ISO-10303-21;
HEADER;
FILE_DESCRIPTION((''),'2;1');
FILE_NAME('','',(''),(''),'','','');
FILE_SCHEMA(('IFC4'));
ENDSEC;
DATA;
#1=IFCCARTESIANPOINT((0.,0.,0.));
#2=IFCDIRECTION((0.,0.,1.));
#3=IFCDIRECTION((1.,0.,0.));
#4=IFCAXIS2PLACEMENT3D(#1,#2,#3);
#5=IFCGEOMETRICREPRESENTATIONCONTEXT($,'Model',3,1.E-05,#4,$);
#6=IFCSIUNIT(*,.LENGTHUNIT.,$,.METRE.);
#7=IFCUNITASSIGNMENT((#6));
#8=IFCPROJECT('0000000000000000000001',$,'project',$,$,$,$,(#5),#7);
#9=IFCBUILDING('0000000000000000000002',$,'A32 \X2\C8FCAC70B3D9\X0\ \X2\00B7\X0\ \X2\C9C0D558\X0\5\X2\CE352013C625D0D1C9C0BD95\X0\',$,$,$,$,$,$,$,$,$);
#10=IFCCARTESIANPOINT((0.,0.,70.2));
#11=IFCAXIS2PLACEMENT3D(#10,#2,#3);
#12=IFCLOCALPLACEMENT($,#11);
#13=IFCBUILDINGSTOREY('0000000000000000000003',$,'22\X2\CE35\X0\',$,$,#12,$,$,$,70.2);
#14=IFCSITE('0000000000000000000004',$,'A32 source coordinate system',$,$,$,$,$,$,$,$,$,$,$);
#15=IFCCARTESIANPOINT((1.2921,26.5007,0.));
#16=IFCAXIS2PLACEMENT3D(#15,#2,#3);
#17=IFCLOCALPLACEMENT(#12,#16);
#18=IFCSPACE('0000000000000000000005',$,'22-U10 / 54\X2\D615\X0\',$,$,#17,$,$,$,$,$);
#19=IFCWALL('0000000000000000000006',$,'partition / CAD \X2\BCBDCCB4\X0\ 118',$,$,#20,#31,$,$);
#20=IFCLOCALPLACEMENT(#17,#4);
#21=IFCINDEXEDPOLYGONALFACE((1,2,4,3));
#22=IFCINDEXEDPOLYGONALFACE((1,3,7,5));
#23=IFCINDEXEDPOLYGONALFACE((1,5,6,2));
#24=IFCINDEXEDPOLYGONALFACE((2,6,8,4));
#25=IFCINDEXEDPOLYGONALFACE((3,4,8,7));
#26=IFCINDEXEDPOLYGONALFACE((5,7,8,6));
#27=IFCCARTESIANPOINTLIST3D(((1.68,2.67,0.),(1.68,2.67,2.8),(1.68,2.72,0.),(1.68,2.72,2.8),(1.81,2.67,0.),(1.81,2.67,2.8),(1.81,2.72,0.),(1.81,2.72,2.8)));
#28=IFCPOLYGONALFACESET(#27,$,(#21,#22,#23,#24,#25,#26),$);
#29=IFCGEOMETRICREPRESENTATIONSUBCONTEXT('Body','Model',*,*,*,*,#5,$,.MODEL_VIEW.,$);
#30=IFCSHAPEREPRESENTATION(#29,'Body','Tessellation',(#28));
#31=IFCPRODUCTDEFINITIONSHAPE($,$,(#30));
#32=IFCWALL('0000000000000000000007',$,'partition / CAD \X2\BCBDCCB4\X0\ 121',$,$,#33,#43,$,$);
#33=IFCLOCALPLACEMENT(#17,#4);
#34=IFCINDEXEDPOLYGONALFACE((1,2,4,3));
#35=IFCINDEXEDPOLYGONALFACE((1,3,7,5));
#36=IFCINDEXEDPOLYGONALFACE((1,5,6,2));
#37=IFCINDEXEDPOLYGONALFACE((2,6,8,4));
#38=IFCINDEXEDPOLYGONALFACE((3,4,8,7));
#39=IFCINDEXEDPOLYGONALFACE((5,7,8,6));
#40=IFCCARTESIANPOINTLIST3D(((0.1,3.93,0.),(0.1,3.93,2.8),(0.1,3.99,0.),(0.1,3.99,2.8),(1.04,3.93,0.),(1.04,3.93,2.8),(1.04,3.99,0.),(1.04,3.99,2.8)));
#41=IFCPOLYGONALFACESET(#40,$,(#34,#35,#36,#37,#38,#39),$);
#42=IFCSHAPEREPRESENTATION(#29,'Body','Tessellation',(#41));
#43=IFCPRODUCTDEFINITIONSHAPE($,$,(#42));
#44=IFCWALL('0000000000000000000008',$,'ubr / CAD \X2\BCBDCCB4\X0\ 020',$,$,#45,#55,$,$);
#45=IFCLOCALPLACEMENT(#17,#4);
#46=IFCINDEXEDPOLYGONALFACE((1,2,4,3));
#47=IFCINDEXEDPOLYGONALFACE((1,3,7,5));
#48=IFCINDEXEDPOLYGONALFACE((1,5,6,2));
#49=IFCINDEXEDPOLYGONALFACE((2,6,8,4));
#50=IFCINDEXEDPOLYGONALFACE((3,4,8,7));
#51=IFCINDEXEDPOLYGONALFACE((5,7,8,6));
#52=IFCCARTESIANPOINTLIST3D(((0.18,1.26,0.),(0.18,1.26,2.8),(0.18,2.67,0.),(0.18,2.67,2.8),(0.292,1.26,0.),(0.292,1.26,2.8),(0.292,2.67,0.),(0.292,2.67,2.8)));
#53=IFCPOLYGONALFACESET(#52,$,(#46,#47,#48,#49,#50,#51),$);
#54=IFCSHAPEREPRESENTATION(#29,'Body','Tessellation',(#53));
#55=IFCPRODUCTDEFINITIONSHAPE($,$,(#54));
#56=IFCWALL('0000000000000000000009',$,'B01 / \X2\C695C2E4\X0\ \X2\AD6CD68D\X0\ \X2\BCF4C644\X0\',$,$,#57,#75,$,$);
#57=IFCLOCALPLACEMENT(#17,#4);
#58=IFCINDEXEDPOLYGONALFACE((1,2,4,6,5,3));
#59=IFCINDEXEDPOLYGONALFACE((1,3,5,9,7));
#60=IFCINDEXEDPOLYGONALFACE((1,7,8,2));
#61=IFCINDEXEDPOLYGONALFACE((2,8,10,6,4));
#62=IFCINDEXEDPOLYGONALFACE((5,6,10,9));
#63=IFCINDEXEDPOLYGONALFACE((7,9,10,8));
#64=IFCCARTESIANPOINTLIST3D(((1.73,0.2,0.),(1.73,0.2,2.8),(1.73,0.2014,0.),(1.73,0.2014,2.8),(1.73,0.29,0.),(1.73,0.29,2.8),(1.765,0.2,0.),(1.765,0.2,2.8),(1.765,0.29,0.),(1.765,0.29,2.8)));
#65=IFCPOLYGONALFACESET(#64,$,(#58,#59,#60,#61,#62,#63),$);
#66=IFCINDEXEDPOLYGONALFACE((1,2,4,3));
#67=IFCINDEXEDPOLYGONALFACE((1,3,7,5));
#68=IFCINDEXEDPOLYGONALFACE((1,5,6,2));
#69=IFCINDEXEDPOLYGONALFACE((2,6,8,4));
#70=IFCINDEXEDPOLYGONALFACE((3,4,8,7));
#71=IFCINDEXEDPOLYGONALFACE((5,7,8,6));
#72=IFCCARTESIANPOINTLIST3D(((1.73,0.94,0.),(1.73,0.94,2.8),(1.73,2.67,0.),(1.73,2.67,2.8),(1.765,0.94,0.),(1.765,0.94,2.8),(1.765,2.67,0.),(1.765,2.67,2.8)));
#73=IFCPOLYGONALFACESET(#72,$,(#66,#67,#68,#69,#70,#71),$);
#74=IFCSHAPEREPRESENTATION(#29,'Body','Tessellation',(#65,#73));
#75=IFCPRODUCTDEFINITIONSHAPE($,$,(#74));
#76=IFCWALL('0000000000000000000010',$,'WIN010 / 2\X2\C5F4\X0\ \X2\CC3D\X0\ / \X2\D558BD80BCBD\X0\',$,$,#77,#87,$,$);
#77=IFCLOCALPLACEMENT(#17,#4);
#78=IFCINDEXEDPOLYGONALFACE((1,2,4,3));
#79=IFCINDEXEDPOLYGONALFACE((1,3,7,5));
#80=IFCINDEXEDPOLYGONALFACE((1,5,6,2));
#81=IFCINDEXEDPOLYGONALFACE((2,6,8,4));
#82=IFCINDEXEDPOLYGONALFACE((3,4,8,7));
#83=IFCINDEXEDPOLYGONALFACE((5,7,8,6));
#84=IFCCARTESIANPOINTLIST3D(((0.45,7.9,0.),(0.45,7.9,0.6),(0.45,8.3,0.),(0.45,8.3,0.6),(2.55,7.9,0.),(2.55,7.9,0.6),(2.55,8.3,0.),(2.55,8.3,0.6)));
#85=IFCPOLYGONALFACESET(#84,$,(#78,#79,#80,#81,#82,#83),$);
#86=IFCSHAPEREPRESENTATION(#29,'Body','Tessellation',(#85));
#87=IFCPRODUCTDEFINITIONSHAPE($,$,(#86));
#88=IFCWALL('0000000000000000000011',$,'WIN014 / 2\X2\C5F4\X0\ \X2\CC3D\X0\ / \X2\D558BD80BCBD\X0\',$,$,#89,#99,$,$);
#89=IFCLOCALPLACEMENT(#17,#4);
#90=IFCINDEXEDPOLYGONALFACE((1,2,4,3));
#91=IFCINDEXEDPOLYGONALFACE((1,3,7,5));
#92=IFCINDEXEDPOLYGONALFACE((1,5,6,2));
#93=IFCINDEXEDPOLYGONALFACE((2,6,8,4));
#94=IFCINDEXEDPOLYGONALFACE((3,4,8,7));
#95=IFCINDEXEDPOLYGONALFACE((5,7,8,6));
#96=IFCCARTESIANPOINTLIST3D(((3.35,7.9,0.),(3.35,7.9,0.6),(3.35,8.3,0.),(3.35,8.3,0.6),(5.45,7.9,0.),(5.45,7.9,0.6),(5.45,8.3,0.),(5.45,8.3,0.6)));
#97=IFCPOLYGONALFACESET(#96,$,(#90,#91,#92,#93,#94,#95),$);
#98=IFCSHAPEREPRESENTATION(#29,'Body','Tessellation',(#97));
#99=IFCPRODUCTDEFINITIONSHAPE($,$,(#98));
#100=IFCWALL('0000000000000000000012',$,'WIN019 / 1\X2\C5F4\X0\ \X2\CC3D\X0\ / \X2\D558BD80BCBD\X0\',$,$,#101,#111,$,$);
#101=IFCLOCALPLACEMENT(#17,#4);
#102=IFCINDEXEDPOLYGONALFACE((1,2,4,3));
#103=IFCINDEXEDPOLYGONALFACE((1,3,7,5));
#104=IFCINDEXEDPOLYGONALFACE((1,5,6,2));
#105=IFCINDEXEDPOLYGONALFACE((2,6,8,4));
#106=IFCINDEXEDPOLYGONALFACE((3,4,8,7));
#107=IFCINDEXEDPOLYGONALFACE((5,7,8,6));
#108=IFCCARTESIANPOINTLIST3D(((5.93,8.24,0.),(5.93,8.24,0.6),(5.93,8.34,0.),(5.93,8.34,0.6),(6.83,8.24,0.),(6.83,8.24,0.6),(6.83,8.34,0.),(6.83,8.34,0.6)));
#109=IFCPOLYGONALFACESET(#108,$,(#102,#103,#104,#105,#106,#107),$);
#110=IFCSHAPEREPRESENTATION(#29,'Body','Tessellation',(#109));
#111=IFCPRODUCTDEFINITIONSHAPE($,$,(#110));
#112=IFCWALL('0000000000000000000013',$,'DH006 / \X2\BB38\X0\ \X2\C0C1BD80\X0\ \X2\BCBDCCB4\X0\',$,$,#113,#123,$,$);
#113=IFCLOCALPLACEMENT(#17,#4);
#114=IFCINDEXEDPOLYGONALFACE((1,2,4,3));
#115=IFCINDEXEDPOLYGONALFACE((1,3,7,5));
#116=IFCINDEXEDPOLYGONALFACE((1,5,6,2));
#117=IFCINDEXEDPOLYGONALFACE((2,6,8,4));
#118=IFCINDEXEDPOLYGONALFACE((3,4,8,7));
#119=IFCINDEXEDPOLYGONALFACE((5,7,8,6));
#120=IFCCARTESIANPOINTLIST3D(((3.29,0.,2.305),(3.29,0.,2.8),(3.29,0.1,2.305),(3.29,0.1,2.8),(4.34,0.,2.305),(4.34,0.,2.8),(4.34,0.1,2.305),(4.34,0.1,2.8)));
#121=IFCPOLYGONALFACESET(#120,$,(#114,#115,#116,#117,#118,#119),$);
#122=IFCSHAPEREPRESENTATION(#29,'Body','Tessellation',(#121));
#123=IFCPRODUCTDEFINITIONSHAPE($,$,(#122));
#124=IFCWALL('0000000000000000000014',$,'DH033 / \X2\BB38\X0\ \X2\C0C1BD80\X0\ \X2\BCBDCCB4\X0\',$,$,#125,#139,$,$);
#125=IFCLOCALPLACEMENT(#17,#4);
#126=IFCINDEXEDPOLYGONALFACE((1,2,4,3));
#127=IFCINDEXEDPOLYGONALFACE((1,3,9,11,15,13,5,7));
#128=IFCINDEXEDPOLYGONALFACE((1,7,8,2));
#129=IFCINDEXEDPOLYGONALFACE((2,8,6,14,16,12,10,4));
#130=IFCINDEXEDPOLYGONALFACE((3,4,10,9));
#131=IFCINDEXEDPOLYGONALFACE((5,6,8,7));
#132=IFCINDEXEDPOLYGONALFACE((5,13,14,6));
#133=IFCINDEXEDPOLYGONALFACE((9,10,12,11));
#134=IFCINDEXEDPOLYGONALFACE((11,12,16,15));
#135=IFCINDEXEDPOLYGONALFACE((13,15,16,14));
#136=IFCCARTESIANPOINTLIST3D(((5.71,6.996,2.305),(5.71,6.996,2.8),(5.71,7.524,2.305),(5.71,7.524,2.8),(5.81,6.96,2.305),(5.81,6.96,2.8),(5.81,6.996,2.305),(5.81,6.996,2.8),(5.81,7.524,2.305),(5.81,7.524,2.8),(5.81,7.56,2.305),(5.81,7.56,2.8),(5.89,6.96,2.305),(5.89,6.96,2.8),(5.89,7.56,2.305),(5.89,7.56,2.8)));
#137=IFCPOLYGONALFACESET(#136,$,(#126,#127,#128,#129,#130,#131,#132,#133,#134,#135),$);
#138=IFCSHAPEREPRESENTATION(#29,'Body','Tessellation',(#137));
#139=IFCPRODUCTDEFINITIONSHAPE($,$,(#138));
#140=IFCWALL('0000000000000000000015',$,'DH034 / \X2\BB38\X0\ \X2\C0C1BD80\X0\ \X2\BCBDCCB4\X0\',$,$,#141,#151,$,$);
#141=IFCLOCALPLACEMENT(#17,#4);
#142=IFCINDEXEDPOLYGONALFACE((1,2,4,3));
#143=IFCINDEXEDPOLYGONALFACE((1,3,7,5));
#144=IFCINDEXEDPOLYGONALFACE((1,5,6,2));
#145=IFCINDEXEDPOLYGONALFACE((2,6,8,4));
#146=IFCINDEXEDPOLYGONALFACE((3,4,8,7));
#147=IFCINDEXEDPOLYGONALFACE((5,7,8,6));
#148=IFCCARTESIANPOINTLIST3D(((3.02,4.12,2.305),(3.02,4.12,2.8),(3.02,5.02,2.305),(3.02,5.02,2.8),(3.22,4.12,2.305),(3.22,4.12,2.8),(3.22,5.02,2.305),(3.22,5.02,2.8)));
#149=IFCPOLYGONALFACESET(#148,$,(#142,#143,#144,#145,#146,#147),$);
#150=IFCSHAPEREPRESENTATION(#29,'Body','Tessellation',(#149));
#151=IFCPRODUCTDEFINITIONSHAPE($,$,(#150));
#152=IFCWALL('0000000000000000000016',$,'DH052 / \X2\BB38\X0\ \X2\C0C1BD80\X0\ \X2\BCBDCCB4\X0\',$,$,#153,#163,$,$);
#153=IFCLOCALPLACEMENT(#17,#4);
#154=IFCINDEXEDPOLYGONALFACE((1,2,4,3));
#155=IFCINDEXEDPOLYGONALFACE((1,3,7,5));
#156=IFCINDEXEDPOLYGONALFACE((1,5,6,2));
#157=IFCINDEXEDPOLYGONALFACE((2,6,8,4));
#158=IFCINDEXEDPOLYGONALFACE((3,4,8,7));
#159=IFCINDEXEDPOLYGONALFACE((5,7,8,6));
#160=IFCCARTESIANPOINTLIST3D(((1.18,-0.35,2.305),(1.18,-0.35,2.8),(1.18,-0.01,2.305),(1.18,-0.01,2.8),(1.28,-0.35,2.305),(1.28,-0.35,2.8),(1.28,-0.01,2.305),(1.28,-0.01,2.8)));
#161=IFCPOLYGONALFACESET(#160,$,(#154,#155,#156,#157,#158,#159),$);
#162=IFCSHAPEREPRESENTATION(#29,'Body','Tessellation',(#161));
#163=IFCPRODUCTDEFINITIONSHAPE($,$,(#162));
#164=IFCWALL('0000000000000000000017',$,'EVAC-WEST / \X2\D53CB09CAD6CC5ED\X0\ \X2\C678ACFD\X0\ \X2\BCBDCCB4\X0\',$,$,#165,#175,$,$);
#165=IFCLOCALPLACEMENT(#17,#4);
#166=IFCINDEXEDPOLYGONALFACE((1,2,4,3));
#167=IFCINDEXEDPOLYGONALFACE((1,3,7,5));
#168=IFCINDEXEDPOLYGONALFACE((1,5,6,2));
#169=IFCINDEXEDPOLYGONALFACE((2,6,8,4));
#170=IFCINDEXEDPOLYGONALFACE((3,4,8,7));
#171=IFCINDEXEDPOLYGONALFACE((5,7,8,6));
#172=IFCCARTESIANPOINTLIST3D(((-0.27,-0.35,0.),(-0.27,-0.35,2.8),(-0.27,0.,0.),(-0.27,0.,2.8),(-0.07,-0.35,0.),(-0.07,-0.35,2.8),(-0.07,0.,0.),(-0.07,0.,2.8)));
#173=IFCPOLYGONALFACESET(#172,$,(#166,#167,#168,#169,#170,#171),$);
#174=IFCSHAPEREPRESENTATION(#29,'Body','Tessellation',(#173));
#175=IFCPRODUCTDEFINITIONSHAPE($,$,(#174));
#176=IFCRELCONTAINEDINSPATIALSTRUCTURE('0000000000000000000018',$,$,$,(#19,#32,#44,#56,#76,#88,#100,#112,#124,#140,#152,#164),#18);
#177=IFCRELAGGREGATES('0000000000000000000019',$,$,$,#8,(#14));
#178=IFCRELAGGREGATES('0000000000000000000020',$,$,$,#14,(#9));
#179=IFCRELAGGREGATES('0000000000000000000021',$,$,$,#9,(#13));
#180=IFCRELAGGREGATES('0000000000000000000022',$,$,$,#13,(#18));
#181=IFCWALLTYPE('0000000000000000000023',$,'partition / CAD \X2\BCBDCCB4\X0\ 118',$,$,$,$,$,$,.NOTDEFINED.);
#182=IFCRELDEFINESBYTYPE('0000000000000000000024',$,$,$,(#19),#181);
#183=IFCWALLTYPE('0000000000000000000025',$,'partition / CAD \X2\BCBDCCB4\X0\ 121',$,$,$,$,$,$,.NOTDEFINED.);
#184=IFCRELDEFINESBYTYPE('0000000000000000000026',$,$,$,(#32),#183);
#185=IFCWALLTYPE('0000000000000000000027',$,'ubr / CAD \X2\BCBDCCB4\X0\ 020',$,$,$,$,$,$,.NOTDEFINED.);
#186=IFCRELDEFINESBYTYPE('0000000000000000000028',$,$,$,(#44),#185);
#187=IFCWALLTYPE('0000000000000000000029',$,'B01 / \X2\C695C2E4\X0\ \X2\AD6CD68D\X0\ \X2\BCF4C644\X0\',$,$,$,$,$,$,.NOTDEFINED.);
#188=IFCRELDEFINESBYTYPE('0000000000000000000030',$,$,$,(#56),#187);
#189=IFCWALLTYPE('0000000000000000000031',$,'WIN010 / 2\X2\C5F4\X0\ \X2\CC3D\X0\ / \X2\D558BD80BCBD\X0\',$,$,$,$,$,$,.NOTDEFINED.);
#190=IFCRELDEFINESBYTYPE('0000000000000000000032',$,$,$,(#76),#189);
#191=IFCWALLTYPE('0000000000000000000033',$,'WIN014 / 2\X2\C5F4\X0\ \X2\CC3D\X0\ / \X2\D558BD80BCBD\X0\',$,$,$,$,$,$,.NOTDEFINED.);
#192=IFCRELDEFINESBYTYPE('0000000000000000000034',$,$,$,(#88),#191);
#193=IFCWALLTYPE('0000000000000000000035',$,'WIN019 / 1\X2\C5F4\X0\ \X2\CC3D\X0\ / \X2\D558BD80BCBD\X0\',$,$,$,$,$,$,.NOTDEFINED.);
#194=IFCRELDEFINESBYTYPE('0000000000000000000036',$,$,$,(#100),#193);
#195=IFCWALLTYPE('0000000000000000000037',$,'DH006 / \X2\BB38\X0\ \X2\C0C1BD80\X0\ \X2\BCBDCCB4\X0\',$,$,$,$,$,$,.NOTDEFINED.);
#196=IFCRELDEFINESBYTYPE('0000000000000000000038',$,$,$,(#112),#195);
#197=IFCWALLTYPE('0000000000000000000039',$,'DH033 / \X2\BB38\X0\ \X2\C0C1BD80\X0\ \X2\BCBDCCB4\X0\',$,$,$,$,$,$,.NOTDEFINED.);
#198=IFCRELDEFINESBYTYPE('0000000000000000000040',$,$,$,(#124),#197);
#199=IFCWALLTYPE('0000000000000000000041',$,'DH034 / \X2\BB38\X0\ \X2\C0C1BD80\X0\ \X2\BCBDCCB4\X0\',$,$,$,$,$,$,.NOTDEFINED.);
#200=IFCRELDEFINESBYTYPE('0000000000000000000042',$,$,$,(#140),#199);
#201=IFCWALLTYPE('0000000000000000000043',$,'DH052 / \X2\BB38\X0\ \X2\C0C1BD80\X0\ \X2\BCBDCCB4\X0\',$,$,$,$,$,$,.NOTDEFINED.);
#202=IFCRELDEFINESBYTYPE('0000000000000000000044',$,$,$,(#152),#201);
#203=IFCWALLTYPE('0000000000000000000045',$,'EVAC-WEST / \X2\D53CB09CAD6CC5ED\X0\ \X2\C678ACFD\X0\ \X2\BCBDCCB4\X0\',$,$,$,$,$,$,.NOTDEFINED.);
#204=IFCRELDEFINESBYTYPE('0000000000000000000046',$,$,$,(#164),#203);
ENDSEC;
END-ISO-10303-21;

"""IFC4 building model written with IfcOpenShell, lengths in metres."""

from ifc_helpers import new_model, si_unit, frame, origin, origin_with_axes, place, context, subcontext, project, spatial, polyline, outline, extrude, source, transform, mapped, type_object, type_shapes, element, save


model = new_model("IFC4")

# Units and contexts
model_context = context("Model", 3, precision=1e-05, world=origin_with_axes())
body_context = subcontext(model_context, "Body", "Model", "MODEL_VIEW")
ifc_project = project(units=[si_unit("LENGTHUNIT", "METRE")], contexts=[model_context])

# Site, building, storey, space
site = spatial("IfcSite", under=ifc_project, Name="A32 source coordinate system")
building = spatial("IfcBuilding", under=site, Name="A32 주거동 · 지하5층–옥탑지붕")
storey_placement = place(None, frame((0.0, 0.0, 70.2), z_axis=(0.0, 0.0, 1.0), x_axis=(1.0, 0.0, 0.0)))
storey = spatial("IfcBuildingStorey", under=building, at=storey_placement, Name="22층", Elevation=70.2)
space_placement = place(storey_placement, frame((1.2921, 26.5007, 0.0), z_axis=(0.0, 0.0, 1.0), x_axis=(1.0, 0.0, 0.0)))
space = spatial("IfcSpace", under=storey, at=space_placement, Name="22-U10 / 54형")

# Walls
wall_type_1 = type_object("IfcWallType", Name="partition / CAD 벽체 118", PredefinedType="NOTDEFINED")
shared_shape_1 = source(origin(), body_context, "Body", "SweptSolid", [
    extrude(outline(polyline([(1.81, 2.67), (1.68, 2.67), (1.68, 2.72), (1.81, 2.72), (1.81, 2.67)])), origin(), (0.0, 0.0, 1.0), 2.8),
])
type_shapes(wall_type_1, [shared_shape_1])
wall_1_placement = place(space_placement, origin_with_axes())
element("IfcWall", 1, at=wall_1_placement, inside=space, type_object=wall_type_1, Name="partition / CAD 벽체 118", context=body_context, shape_type="MappedRepresentation", body=[
    mapped(shared_shape_1, transform((0.0, 0.0, 0.0), scale=1.0)),
])
wall_type_2 = type_object("IfcWallType", Name="partition / CAD 벽체 121", PredefinedType="NOTDEFINED")
shared_shape_2 = source(origin(), body_context, "Body", "SweptSolid", [
    extrude(outline(polyline([(0.1, 3.99), (1.04, 3.99), (1.04, 3.93), (0.1, 3.93), (0.1, 3.99)])), origin(), (0.0, 0.0, 1.0), 2.8),
])
type_shapes(wall_type_2, [shared_shape_2])
wall_2_placement = place(space_placement, origin_with_axes())
element("IfcWall", 2, at=wall_2_placement, inside=space, type_object=wall_type_2, Name="partition / CAD 벽체 121", context=body_context, shape_type="MappedRepresentation", body=[
    mapped(shared_shape_2, transform((0.0, 0.0, 0.0), scale=1.0)),
])
wall_type_3 = type_object("IfcWallType", Name="ubr / CAD 벽체 020", PredefinedType="NOTDEFINED")
shared_shape_3 = source(origin(), body_context, "Body", "SweptSolid", [
    extrude(outline(polyline([(0.18, 1.26), (0.18, 2.67), (0.292, 2.67), (0.292, 1.26), (0.18, 1.26)])), origin(), (0.0, 0.0, 1.0), 2.8),
])
type_shapes(wall_type_3, [shared_shape_3])
wall_3_placement = place(space_placement, origin_with_axes())
element("IfcWall", 3, at=wall_3_placement, inside=space, type_object=wall_type_3, Name="ubr / CAD 벽체 020", context=body_context, shape_type="MappedRepresentation", body=[
    mapped(shared_shape_3, transform((0.0, 0.0, 0.0), scale=1.0)),
])
wall_type_4 = type_object("IfcWallType", Name="B01 / 욕실 구획 보완", PredefinedType="NOTDEFINED")
shared_shape_4 = source(origin(), body_context, "Body", "SweptSolid", [
    extrude(outline(polyline([(1.765, 0.2), (1.73, 0.2), (1.73, 0.2014), (1.73, 0.29), (1.765, 0.29), (1.765, 0.2)])), origin(), (0.0, 0.0, 1.0), 2.8),
    extrude(outline(polyline([(1.765, 2.67), (1.765, 0.94), (1.73, 0.94), (1.73, 2.67), (1.765, 2.67)])), origin(), (0.0, 0.0, 1.0), 2.8),
])
type_shapes(wall_type_4, [shared_shape_4])
wall_4_placement = place(space_placement, origin_with_axes())
element("IfcWall", 4, at=wall_4_placement, inside=space, type_object=wall_type_4, Name="B01 / 욕실 구획 보완", context=body_context, shape_type="MappedRepresentation", body=[
    mapped(shared_shape_4, transform((0.0, 0.0, 0.0), scale=1.0)),
])
wall_type_5 = type_object("IfcWallType", Name="WIN010 / 2열 창 / 하부벽", PredefinedType="NOTDEFINED")
shared_shape_5 = source(origin(), body_context, "Body", "SweptSolid", [
    extrude(outline(polyline([(2.55, 8.3), (2.55, 7.9), (0.45, 7.9), (0.45, 8.3), (2.55, 8.3)])), origin(), (0.0, 0.0, 1.0), 0.6),
])
type_shapes(wall_type_5, [shared_shape_5])
wall_5_placement = place(space_placement, origin_with_axes())
element("IfcWall", 5, at=wall_5_placement, inside=space, type_object=wall_type_5, Name="WIN010 / 2열 창 / 하부벽", context=body_context, shape_type="MappedRepresentation", body=[
    mapped(shared_shape_5, transform((0.0, 0.0, 0.0), scale=1.0)),
])
wall_type_6 = type_object("IfcWallType", Name="WIN014 / 2열 창 / 하부벽", PredefinedType="NOTDEFINED")
shared_shape_6 = source(origin(), body_context, "Body", "SweptSolid", [
    extrude(outline(polyline([(5.45, 8.3), (5.45, 7.9), (3.35, 7.9), (3.35, 8.3), (5.45, 8.3)])), origin(), (0.0, 0.0, 1.0), 0.6),
])
type_shapes(wall_type_6, [shared_shape_6])
wall_6_placement = place(space_placement, origin_with_axes())
element("IfcWall", 6, at=wall_6_placement, inside=space, type_object=wall_type_6, Name="WIN014 / 2열 창 / 하부벽", context=body_context, shape_type="MappedRepresentation", body=[
    mapped(shared_shape_6, transform((0.0, 0.0, 0.0), scale=1.0)),
])
wall_type_7 = type_object("IfcWallType", Name="WIN019 / 1열 창 / 하부벽", PredefinedType="NOTDEFINED")
shared_shape_7 = source(origin(), body_context, "Body", "SweptSolid", [
    extrude(outline(polyline([(6.83, 8.34), (6.83, 8.24), (5.93, 8.24), (5.93, 8.34), (6.83, 8.34)])), origin(), (0.0, 0.0, 1.0), 0.6),
])
type_shapes(wall_type_7, [shared_shape_7])
wall_7_placement = place(space_placement, origin_with_axes())
element("IfcWall", 7, at=wall_7_placement, inside=space, type_object=wall_type_7, Name="WIN019 / 1열 창 / 하부벽", context=body_context, shape_type="MappedRepresentation", body=[
    mapped(shared_shape_7, transform((0.0, 0.0, 0.0), scale=1.0)),
])
wall_type_8 = type_object("IfcWallType", Name="DH006 / 문 상부 벽체", PredefinedType="NOTDEFINED")
shared_shape_8 = source(origin(), body_context, "Body", "SweptSolid", [
    extrude(outline(polyline([(4.34, 0.0), (3.29, 0.0), (3.29, 0.1), (4.34, 0.1), (4.34, 0.0)])), frame((0.0, 0.0, 2.305)), (0.0, 0.0, 1.0), 0.495),
])
type_shapes(wall_type_8, [shared_shape_8])
wall_8_placement = place(space_placement, origin_with_axes())
element("IfcWall", 8, at=wall_8_placement, inside=space, type_object=wall_type_8, Name="DH006 / 문 상부 벽체", context=body_context, shape_type="MappedRepresentation", body=[
    mapped(shared_shape_8, transform((0.0, 0.0, 0.0), scale=1.0)),
])
wall_type_9 = type_object("IfcWallType", Name="DH033 / 문 상부 벽체", PredefinedType="NOTDEFINED")
shared_shape_9 = source(origin(), body_context, "Body", "SweptSolid", [
    extrude(outline(polyline([(5.81, 6.996), (5.71, 6.996), (5.71, 7.524), (5.81, 7.524), (5.81, 7.56), (5.89, 7.56), (5.89, 6.96), (5.81, 6.96), (5.81, 6.996)])), frame((0.0, 0.0, 2.305)), (0.0, 0.0, 1.0), 0.495),
])
type_shapes(wall_type_9, [shared_shape_9])
wall_9_placement = place(space_placement, origin_with_axes())
element("IfcWall", 9, at=wall_9_placement, inside=space, type_object=wall_type_9, Name="DH033 / 문 상부 벽체", context=body_context, shape_type="MappedRepresentation", body=[
    mapped(shared_shape_9, transform((0.0, 0.0, 0.0), scale=1.0)),
])
wall_type_10 = type_object("IfcWallType", Name="DH034 / 문 상부 벽체", PredefinedType="NOTDEFINED")
shared_shape_10 = source(origin(), body_context, "Body", "SweptSolid", [
    extrude(outline(polyline([(3.22, 4.12), (3.02, 4.12), (3.02, 5.02), (3.22, 5.02), (3.22, 4.12)])), frame((0.0, 0.0, 2.305)), (0.0, 0.0, 1.0), 0.495),
])
type_shapes(wall_type_10, [shared_shape_10])
wall_10_placement = place(space_placement, origin_with_axes())
element("IfcWall", 10, at=wall_10_placement, inside=space, type_object=wall_type_10, Name="DH034 / 문 상부 벽체", context=body_context, shape_type="MappedRepresentation", body=[
    mapped(shared_shape_10, transform((0.0, 0.0, 0.0), scale=1.0)),
])
wall_type_11 = type_object("IfcWallType", Name="DH052 / 문 상부 벽체", PredefinedType="NOTDEFINED")
shared_shape_11 = source(origin(), body_context, "Body", "SweptSolid", [
    extrude(outline(polyline([(1.28, -0.35), (1.18, -0.35), (1.18, -0.01), (1.28, -0.01), (1.28, -0.35)])), frame((0.0, 0.0, 2.305)), (0.0, 0.0, 1.0), 0.495),
])
type_shapes(wall_type_11, [shared_shape_11])
wall_11_placement = place(space_placement, origin_with_axes())
element("IfcWall", 11, at=wall_11_placement, inside=space, type_object=wall_type_11, Name="DH052 / 문 상부 벽체", context=body_context, shape_type="MappedRepresentation", body=[
    mapped(shared_shape_11, transform((0.0, 0.0, 0.0), scale=1.0)),
])
wall_type_12 = type_object("IfcWallType", Name="EVAC-WEST / 피난구역 외곽 벽체", PredefinedType="NOTDEFINED")
shared_shape_12 = source(origin(), body_context, "Body", "SweptSolid", [
    extrude(outline(polyline([(-0.07, 0.0), (-0.07, -0.35), (-0.27, -0.35), (-0.27, 0.0), (-0.07, 0.0)])), origin(), (0.0, 0.0, 1.0), 2.8),
])
type_shapes(wall_type_12, [shared_shape_12])
wall_12_placement = place(space_placement, origin_with_axes())
element("IfcWall", 12, at=wall_12_placement, inside=space, type_object=wall_type_12, Name="EVAC-WEST / 피난구역 외곽 벽체", context=body_context, shape_type="MappedRepresentation", body=[
    mapped(shared_shape_12, transform((0.0, 0.0, 0.0), scale=1.0)),
])

save(model, "model.ifc")
